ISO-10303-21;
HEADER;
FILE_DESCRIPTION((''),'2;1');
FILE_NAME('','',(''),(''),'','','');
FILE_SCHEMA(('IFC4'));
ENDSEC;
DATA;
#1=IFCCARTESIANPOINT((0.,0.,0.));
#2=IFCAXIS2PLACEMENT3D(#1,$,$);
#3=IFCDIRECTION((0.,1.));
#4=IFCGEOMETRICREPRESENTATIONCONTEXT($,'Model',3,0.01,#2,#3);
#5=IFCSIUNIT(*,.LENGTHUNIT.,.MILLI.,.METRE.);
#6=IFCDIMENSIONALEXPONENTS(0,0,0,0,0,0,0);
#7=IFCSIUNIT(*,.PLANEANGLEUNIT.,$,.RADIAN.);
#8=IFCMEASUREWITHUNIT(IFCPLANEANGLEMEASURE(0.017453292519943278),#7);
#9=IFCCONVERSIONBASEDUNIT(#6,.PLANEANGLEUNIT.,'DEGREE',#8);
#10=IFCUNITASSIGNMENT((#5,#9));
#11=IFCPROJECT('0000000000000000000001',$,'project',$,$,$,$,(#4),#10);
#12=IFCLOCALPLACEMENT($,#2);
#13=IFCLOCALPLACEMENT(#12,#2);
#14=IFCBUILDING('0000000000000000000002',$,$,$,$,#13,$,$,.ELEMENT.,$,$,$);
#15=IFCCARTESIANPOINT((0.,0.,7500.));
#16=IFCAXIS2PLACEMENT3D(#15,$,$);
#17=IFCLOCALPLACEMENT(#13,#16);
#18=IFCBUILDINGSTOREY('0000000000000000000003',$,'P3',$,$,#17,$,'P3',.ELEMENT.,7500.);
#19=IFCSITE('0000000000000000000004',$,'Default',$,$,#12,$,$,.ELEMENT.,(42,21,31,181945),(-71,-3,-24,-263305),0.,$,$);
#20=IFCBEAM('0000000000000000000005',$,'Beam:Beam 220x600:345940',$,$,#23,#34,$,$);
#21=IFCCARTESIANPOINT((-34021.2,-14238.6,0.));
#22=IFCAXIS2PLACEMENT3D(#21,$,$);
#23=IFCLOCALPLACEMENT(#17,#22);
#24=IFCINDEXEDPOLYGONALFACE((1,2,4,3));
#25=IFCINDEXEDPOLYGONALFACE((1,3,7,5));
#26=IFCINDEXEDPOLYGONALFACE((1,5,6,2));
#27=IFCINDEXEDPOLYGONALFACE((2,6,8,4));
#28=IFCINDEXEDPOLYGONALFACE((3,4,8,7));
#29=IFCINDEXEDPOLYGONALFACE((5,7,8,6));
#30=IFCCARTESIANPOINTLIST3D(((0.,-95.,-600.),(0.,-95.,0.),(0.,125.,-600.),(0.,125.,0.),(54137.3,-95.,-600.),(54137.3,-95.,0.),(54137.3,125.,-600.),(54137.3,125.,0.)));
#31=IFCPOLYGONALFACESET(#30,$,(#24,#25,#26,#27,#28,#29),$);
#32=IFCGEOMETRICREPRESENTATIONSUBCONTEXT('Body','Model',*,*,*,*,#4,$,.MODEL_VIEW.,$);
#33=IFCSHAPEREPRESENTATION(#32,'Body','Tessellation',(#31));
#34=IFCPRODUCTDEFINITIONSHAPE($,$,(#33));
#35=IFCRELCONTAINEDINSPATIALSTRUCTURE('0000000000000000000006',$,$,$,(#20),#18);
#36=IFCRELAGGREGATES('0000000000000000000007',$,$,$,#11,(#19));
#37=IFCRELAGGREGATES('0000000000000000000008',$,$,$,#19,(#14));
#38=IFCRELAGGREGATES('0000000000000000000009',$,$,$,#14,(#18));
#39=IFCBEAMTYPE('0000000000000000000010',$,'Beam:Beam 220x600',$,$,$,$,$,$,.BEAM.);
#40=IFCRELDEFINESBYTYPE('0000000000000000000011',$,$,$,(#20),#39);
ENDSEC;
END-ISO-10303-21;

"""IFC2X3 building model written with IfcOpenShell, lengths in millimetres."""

from ifc_helpers import new_model, entity, si_unit, converted_unit, direction, frame, frame_2d, origin, place, context, subcontext, project, spatial, rectangle, extrude, type_object, element, save


model = new_model("IFC2X3")

# Units and contexts
model_context = context("Model", 3, precision=0.01, world=origin(), true_north=direction((0.0, 1.0)))
body_context = subcontext(model_context, "Body", "Model", "MODEL_VIEW")
ifc_project = project(units=[si_unit("LENGTHUNIT", "METRE", prefix="MILLI"), converted_unit("PLANEANGLEUNIT", "DEGREE", entity("IfcPlaneAngleMeasure", 0.017453292519943278), si_unit("PLANEANGLEUNIT", "RADIAN"), dimensions=[0, 0, 0, 0, 0, 0, 0])], contexts=[model_context])

# Site, building, storey
site_placement = place(None, origin())
site = spatial("IfcSite", under=ifc_project, at=site_placement, Name="Default", CompositionType="ELEMENT", RefLatitude=(42, 21, 31, 181945), RefLongitude=(-71, -3, -24, -263305), RefElevation=0.0)
building_placement = place(site_placement, origin())
building = spatial("IfcBuilding", under=site, at=building_placement, CompositionType="ELEMENT")
storey_placement = place(building_placement, frame((0.0, 0.0, 7500.0)))
storey = spatial("IfcBuildingStorey", under=building, at=storey_placement, Name="P3", LongName="P3", CompositionType="ELEMENT", Elevation=7500.0)

# Beam
beam_type_1 = type_object("IfcBeamType", Name="Beam:Beam 220x600", PredefinedType="BEAM")
beam_1_placement = place(storey_placement, frame((-34021.2, -14238.6, 0.0)))
element("IfcBeam", 1, at=beam_1_placement, inside=storey, type_object=beam_type_1, Name="Beam:Beam 220x600:345940", context=body_context, shape_type="SweptSolid", body=[
    extrude(rectangle(XDim=600.0, YDim=220.0, at=frame_2d((0.0, 0.0), x_axis=(1.0, 0.0))), frame((0.0, 15.0, -300.0), z_axis=(1.0, 0.0, 0.0), x_axis=(0.0, 0.0, -1.0)), (0.0, 0.0, 1.0), 54137.3),
])

save(model, "model.ifc")
